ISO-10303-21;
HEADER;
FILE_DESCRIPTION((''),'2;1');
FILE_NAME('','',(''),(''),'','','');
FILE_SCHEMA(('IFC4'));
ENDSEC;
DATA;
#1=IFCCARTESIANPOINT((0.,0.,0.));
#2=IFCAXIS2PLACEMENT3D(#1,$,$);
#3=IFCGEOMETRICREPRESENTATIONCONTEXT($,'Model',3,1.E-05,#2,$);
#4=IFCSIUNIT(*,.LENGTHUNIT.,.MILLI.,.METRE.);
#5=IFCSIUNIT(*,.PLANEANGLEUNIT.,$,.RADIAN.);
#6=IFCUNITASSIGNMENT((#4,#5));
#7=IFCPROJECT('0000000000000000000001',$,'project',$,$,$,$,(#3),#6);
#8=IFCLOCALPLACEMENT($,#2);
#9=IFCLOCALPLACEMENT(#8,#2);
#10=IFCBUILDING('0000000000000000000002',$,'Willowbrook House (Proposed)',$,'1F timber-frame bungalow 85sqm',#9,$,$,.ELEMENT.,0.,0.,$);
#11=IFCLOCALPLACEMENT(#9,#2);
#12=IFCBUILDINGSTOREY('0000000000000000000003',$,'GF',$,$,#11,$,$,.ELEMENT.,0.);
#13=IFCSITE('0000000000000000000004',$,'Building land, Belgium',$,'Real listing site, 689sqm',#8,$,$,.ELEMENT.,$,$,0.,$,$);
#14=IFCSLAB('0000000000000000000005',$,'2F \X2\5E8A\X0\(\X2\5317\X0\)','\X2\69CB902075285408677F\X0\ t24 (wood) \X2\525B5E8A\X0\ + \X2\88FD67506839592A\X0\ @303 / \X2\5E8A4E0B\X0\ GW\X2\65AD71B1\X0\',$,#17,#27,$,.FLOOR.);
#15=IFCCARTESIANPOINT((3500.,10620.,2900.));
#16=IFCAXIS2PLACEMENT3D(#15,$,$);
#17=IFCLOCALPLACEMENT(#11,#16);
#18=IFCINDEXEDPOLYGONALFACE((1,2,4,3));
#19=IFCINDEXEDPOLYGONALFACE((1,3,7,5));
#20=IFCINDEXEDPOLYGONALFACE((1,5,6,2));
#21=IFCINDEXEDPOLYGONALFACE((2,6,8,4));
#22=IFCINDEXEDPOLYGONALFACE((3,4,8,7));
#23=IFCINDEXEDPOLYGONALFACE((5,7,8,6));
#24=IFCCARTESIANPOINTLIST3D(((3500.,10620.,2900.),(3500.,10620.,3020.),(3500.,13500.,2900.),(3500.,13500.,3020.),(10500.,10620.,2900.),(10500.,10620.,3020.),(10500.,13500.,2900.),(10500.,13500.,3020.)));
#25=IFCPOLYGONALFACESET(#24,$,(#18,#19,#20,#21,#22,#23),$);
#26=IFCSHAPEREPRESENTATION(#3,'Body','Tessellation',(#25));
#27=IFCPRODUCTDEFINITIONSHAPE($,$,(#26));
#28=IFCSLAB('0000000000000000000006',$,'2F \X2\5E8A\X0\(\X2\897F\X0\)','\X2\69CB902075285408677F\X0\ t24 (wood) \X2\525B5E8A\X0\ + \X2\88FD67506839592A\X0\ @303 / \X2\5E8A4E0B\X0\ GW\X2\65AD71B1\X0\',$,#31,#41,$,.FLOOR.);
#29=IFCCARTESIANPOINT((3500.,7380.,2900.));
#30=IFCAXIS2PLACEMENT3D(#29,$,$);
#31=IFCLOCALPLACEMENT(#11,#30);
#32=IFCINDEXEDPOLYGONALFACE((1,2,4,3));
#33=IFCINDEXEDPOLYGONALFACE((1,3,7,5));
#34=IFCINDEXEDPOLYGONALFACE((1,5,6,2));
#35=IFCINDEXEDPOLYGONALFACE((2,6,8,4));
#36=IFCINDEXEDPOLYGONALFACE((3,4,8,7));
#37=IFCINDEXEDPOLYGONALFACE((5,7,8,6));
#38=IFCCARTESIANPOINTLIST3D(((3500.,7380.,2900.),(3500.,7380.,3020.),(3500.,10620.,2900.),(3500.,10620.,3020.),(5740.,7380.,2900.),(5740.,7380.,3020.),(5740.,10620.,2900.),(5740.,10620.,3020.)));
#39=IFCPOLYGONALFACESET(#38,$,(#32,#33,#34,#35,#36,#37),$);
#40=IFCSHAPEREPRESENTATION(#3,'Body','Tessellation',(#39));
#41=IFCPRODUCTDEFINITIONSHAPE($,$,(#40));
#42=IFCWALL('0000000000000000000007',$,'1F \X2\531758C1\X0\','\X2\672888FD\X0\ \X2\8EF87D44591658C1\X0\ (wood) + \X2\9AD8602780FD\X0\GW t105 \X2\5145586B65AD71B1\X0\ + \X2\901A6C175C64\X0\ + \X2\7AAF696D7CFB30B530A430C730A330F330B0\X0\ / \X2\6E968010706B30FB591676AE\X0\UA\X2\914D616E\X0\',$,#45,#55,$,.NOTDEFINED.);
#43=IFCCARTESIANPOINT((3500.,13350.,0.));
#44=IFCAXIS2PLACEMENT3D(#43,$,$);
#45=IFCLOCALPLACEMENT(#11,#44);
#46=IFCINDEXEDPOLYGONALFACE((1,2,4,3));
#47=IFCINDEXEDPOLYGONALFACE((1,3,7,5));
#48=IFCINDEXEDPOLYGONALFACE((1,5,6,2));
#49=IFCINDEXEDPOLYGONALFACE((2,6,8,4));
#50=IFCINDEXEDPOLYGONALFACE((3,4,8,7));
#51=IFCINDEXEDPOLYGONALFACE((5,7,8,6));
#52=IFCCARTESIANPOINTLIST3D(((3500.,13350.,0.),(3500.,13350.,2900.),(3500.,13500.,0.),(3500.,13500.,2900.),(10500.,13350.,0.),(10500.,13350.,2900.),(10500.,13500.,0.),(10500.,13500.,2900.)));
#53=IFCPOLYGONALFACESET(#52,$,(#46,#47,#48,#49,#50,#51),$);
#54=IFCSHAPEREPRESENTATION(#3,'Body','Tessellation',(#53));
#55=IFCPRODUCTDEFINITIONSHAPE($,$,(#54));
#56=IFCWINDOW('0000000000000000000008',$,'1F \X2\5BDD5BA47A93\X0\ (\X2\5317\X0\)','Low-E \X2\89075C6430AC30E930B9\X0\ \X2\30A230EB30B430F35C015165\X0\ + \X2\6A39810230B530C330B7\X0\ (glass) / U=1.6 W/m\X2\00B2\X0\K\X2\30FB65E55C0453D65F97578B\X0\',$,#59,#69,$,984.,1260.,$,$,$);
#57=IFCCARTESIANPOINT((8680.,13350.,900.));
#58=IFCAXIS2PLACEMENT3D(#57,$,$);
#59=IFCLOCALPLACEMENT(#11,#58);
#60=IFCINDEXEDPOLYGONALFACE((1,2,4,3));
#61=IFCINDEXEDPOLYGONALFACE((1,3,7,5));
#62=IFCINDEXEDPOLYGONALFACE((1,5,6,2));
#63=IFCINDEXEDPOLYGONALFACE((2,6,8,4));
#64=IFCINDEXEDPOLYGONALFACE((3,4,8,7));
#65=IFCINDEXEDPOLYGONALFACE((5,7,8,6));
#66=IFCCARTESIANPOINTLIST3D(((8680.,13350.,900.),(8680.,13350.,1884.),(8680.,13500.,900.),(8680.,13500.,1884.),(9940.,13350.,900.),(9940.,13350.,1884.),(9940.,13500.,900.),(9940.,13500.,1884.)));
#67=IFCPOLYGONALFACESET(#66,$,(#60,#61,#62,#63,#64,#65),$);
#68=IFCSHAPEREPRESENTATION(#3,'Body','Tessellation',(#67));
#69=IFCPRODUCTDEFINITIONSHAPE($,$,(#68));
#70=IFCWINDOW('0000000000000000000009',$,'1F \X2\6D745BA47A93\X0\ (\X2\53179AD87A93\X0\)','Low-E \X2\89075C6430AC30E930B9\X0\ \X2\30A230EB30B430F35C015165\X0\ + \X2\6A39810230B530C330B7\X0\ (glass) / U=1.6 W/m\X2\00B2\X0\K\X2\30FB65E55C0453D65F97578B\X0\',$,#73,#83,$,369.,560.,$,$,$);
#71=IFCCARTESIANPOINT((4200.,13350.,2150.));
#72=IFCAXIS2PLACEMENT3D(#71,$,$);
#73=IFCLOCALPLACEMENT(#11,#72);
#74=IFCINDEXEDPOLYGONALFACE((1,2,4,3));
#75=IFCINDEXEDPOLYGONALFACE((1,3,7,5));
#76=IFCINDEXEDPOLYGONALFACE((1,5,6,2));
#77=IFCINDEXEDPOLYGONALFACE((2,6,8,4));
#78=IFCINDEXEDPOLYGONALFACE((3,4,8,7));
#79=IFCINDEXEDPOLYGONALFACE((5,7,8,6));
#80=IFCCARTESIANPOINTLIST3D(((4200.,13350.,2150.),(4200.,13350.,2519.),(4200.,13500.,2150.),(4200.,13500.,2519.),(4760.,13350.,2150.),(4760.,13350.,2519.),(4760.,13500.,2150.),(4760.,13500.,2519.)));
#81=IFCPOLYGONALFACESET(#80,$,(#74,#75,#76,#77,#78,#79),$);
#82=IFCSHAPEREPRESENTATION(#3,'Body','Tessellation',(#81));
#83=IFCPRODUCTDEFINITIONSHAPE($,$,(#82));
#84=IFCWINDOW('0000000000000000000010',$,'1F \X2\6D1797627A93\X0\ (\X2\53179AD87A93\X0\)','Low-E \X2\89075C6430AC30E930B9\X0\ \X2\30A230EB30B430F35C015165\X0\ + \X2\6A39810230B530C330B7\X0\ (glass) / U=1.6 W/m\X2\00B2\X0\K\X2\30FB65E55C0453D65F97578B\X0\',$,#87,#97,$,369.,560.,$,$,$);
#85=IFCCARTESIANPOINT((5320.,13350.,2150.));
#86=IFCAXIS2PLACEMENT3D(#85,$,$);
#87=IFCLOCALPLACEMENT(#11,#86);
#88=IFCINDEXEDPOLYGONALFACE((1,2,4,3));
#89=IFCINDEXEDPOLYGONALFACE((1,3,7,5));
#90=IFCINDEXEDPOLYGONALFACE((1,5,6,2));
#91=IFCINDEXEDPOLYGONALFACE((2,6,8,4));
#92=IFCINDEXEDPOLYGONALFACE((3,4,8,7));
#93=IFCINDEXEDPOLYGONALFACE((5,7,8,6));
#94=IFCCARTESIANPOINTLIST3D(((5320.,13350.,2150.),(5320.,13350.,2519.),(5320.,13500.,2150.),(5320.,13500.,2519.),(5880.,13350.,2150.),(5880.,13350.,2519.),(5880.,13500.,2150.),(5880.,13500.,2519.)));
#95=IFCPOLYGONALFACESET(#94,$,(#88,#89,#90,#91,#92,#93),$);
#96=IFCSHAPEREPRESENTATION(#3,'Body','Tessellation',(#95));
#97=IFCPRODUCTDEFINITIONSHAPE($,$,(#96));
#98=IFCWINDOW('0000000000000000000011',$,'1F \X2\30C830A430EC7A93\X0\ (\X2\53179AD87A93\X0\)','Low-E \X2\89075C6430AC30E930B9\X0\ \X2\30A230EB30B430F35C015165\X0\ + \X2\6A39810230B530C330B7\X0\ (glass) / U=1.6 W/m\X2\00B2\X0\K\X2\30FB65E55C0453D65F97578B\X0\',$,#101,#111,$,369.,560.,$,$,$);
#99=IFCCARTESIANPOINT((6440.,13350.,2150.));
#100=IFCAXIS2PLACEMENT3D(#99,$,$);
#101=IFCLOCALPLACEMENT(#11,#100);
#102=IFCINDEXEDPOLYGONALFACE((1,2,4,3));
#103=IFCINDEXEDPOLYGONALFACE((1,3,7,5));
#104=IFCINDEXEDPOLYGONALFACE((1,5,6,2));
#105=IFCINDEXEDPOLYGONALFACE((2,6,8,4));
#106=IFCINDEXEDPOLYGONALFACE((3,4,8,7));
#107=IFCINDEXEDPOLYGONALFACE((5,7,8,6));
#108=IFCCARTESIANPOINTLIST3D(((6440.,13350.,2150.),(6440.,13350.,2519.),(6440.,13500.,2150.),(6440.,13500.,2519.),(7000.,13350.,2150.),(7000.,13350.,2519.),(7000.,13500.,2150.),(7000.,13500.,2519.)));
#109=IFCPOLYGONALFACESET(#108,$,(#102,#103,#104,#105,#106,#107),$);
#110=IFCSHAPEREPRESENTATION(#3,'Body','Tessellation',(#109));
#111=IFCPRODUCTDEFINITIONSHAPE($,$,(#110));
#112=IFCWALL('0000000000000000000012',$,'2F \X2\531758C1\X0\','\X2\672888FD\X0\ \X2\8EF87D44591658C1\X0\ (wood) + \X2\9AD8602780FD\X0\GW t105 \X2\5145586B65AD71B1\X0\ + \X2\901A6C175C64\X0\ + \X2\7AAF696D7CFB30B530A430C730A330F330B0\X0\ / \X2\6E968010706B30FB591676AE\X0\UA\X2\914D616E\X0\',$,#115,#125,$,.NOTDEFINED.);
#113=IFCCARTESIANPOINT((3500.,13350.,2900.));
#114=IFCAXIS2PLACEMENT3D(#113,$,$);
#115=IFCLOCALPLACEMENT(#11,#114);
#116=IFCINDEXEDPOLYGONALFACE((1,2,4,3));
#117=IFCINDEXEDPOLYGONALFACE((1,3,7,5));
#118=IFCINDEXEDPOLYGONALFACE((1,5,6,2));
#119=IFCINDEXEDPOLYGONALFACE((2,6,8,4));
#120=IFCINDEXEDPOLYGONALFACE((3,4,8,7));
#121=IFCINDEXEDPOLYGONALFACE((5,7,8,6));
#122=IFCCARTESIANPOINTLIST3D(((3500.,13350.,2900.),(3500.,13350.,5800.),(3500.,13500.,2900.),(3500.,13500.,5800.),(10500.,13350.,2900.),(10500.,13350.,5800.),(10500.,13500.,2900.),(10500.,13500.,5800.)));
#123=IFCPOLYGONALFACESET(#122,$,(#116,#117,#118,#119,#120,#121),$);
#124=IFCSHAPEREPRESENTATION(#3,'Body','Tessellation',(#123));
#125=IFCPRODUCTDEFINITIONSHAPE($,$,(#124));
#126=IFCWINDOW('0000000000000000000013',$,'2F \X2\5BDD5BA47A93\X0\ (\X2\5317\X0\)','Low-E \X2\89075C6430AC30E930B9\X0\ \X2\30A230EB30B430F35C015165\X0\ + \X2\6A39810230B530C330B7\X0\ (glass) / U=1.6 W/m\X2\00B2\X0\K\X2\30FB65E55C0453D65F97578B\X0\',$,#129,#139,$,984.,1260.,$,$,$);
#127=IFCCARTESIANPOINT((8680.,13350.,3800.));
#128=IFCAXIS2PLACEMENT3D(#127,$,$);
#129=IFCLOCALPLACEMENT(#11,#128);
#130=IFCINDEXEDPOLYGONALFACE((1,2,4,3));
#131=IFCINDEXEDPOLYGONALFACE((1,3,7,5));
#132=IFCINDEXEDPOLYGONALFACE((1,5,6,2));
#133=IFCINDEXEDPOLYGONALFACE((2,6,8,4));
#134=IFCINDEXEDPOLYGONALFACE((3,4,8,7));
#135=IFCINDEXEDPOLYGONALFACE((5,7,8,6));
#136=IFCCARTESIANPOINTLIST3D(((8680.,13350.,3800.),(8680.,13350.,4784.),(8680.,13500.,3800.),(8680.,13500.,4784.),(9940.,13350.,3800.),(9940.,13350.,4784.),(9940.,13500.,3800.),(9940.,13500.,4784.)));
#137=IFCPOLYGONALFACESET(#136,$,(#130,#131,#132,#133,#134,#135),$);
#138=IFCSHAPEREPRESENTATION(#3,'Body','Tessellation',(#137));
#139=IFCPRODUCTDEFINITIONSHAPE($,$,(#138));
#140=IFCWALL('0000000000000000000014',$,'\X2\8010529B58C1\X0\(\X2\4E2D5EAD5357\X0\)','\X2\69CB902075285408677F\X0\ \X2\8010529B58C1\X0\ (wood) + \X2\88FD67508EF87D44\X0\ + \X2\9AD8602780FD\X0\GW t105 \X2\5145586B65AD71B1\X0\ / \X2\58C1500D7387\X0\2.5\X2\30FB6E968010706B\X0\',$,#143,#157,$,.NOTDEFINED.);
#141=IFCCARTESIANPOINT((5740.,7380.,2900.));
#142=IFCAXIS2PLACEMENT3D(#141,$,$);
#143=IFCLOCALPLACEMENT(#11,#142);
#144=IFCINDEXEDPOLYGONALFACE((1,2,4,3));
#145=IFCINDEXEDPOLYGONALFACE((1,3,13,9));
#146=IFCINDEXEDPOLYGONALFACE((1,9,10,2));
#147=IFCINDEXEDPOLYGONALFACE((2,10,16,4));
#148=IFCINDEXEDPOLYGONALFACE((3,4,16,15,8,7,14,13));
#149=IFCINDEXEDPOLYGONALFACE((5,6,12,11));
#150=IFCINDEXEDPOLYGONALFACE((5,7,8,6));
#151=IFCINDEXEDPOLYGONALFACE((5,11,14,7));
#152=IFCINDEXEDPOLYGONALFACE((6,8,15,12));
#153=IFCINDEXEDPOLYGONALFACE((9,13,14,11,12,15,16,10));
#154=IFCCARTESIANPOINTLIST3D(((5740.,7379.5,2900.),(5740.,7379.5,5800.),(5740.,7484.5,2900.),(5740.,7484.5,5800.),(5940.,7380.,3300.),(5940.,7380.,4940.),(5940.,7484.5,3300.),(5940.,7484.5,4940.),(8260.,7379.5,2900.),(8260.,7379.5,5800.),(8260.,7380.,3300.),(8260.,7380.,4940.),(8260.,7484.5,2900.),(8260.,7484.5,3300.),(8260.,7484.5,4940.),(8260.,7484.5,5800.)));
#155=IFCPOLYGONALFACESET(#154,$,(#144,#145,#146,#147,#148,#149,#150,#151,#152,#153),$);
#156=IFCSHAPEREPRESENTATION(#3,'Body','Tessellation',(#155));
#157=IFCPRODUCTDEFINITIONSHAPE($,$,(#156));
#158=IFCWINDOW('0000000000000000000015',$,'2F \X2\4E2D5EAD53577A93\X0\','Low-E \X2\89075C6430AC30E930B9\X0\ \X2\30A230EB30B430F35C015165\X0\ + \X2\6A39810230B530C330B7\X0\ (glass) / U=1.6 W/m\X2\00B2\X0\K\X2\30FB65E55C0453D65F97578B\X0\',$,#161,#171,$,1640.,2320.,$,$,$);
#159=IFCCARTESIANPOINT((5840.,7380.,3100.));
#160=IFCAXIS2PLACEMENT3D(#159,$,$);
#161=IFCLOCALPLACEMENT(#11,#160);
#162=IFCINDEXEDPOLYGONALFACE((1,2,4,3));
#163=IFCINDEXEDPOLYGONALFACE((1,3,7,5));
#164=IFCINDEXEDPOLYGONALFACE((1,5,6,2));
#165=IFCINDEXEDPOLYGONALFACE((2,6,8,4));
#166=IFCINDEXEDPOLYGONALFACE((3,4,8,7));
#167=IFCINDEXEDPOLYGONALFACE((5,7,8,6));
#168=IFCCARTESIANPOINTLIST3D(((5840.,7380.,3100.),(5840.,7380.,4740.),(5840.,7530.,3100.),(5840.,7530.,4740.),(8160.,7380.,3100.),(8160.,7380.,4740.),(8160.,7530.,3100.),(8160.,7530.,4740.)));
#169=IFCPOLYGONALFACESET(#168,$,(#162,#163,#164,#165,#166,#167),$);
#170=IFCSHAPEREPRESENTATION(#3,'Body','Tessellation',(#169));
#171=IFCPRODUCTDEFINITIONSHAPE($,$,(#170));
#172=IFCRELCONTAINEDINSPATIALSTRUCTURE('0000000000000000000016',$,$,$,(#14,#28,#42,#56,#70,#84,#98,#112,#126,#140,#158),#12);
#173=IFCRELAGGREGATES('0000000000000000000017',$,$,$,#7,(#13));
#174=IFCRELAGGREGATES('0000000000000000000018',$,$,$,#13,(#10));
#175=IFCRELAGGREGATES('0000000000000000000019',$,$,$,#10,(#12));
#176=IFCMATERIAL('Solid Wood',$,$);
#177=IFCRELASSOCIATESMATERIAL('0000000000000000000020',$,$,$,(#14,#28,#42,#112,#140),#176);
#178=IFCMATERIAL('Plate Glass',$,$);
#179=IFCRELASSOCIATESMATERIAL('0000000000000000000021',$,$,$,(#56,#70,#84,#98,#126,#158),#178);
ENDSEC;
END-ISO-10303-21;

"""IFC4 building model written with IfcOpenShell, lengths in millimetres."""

from ifc_helpers import new_model, si_unit, frame, frame_2d, origin, place, context, project, spatial, rectangle, extrude, material, element, fill, save


model = new_model("IFC4")

# Units and contexts
model_context = context("Model", 3, precision=1e-05, world=origin())
ifc_project = project(units=[si_unit("LENGTHUNIT", "METRE", prefix="MILLI"), si_unit("PLANEANGLEUNIT", "RADIAN")], contexts=[model_context])

# Site, building, storey
site_placement = place(None, origin())
site = spatial("IfcSite", under=ifc_project, at=site_placement, Name="Building land, Belgium", ObjectType="Real listing site, 689sqm", CompositionType="ELEMENT", RefElevation=0.0)
building_placement = place(site_placement, origin())
building = spatial("IfcBuilding", under=site, at=building_placement, Name="Willowbrook House (Proposed)", ObjectType="1F timber-frame bungalow 85sqm", CompositionType="ELEMENT", ElevationOfRefHeight=0.0, ElevationOfTerrain=0.0)
storey_placement = place(building_placement, origin())
storey = spatial("IfcBuildingStorey", under=building, at=storey_placement, Name="GF", CompositionType="ELEMENT", Elevation=0.0)

# Slabs
ifc_material_1 = material(Name="Solid Wood")
slab_1_placement = place(storey_placement, frame((3500.0, 10620.0, 2900.0)))
element("IfcSlab", 1, at=slab_1_placement, inside=storey, material=ifc_material_1, Name="2F 床(北)", Description="構造用合板 t24 (wood) 剛床 + 製材根太 @303 / 床下 GW断熱", PredefinedType="FLOOR", context=model_context, shape_type="SweptSolid", body=[
    extrude(rectangle(XDim=7000.0, YDim=2880.0, at=frame_2d((3500.0, 1440.0))), frame((3500.0, 10620.0, 2900.0)), (0.0, 0.0, 1.0), 120.0),
])
slab_2_placement = place(storey_placement, frame((3500.0, 7380.0, 2900.0)))
element("IfcSlab", 2, at=slab_2_placement, inside=storey, material=ifc_material_1, Name="2F 床(西)", Description="構造用合板 t24 (wood) 剛床 + 製材根太 @303 / 床下 GW断熱", PredefinedType="FLOOR", context=model_context, shape_type="SweptSolid", body=[
    extrude(rectangle(XDim=2240.0, YDim=3240.0, at=frame_2d((1120.0, 1620.0))), frame((3500.0, 7380.0, 2900.0)), (0.0, 0.0, 1.0), 120.0),
])

# Wall, openings, windows
wall_1_placement = place(storey_placement, frame((3500.0, 13350.0, 0.0)))
wall_1 = element("IfcWall", 3, at=wall_1_placement, inside=storey, material=ifc_material_1, Name="1F 北壁", Description="木製 軸組外壁 (wood) + 高性能GW t105 充填断熱 + 通気層 + 窯業系サイディング / 準耐火・外皮UA配慮", PredefinedType="NOTDEFINED", context=model_context, shape_type="SweptSolid", body=[
    extrude(rectangle(XDim=7000.0, YDim=150.0, at=frame_2d((3500.0, 75.0))), frame((3500.0, 13350.0, 0.0)), (0.0, 0.0, 1.0), 2900.0),
])
opening_1_placement = place(storey_placement, frame((8680.0, 13350.0, 900.0)))
opening_1 = element("IfcOpeningElement", 4, at=opening_1_placement, cuts=wall_1, PredefinedType="NOTDEFINED", context=model_context, shape_type="SweptSolid", body=[
    extrude(rectangle(XDim=1260.0, YDim=150.0, at=frame_2d((630.0, 75.0))), frame((8680.0, 13350.0, 900.0)), (0.0, 0.0, 1.0), 984.0),
])
opening_2_placement = place(storey_placement, frame((4200.0, 13350.0, 2150.0)))
opening_2 = element("IfcOpeningElement", 5, at=opening_2_placement, cuts=wall_1, PredefinedType="NOTDEFINED", context=model_context, shape_type="SweptSolid", body=[
    extrude(rectangle(XDim=560.0, YDim=150.0, at=frame_2d((280.0, 75.0))), frame((4200.0, 13350.0, 2150.0)), (0.0, 0.0, 1.0), 369.0),
])
opening_3_placement = place(storey_placement, frame((5320.0, 13350.0, 2150.0)))
opening_3 = element("IfcOpeningElement", 6, at=opening_3_placement, cuts=wall_1, PredefinedType="NOTDEFINED", context=model_context, shape_type="SweptSolid", body=[
    extrude(rectangle(XDim=560.0, YDim=150.0, at=frame_2d((280.0, 75.0))), frame((5320.0, 13350.0, 2150.0)), (0.0, 0.0, 1.0), 369.0),
])
opening_4_placement = place(storey_placement, frame((6440.0, 13350.0, 2150.0)))
opening_4 = element("IfcOpeningElement", 7, at=opening_4_placement, cuts=wall_1, PredefinedType="NOTDEFINED", context=model_context, shape_type="SweptSolid", body=[
    extrude(rectangle(XDim=560.0, YDim=150.0, at=frame_2d((280.0, 75.0))), frame((6440.0, 13350.0, 2150.0)), (0.0, 0.0, 1.0), 369.0),
])
ifc_material_2 = material(Name="Plate Glass")
window_1_placement = place(storey_placement, frame((8680.0, 13350.0, 900.0)))
window_1 = element("IfcWindow", 8, at=window_1_placement, inside=storey, material=ifc_material_2, Name="1F 寝室窓 (北)", Description="Low-E 複層ガラス アルゴン封入 + 樹脂サッシ (glass) / U=1.6 W/m²K・日射取得型", OverallHeight=984.0, OverallWidth=1260.0, context=model_context, shape_type="SweptSolid", body=[
    extrude(rectangle(XDim=1260.0, YDim=150.0, at=frame_2d((630.0, 75.0))), frame((8680.0, 13350.0, 900.0)), (0.0, 0.0, 1.0), 984.0),
])
fill(opening_1, window_1)
window_2_placement = place(storey_placement, frame((4200.0, 13350.0, 2150.0)))
window_2 = element("IfcWindow", 9, at=window_2_placement, inside=storey, material=ifc_material_2, Name="1F 浴室窓 (北高窓)", Description="Low-E 複層ガラス アルゴン封入 + 樹脂サッシ (glass) / U=1.6 W/m²K・日射取得型", OverallHeight=369.0, OverallWidth=560.0, context=model_context, shape_type="SweptSolid", body=[
    extrude(rectangle(XDim=560.0, YDim=150.0, at=frame_2d((280.0, 75.0))), frame((4200.0, 13350.0, 2150.0)), (0.0, 0.0, 1.0), 369.0),
])
fill(opening_2, window_2)
window_3_placement = place(storey_placement, frame((5320.0, 13350.0, 2150.0)))
window_3 = element("IfcWindow", 10, at=window_3_placement, inside=storey, material=ifc_material_2, Name="1F 洗面窓 (北高窓)", Description="Low-E 複層ガラス アルゴン封入 + 樹脂サッシ (glass) / U=1.6 W/m²K・日射取得型", OverallHeight=369.0, OverallWidth=560.0, context=model_context, shape_type="SweptSolid", body=[
    extrude(rectangle(XDim=560.0, YDim=150.0, at=frame_2d((280.0, 75.0))), frame((5320.0, 13350.0, 2150.0)), (0.0, 0.0, 1.0), 369.0),
])
fill(opening_3, window_3)
window_4_placement = place(storey_placement, frame((6440.0, 13350.0, 2150.0)))
window_4 = element("IfcWindow", 11, at=window_4_placement, inside=storey, material=ifc_material_2, Name="1F トイレ窓 (北高窓)", Description="Low-E 複層ガラス アルゴン封入 + 樹脂サッシ (glass) / U=1.6 W/m²K・日射取得型", OverallHeight=369.0, OverallWidth=560.0, context=model_context, shape_type="SweptSolid", body=[
    extrude(rectangle(XDim=560.0, YDim=150.0, at=frame_2d((280.0, 75.0))), frame((6440.0, 13350.0, 2150.0)), (0.0, 0.0, 1.0), 369.0),
])
fill(opening_4, window_4)

# Walls, openings, windows
wall_2_placement = place(storey_placement, frame((3500.0, 13350.0, 2900.0)))
wall_2 = element("IfcWall", 12, at=wall_2_placement, inside=storey, material=ifc_material_1, Name="2F 北壁", Description="木製 軸組外壁 (wood) + 高性能GW t105 充填断熱 + 通気層 + 窯業系サイディング / 準耐火・外皮UA配慮", PredefinedType="NOTDEFINED", context=model_context, shape_type="SweptSolid", body=[
    extrude(rectangle(XDim=7000.0, YDim=150.0, at=frame_2d((3500.0, 75.0))), frame((3500.0, 13350.0, 2900.0)), (0.0, 0.0, 1.0), 2900.0),
])
opening_5_placement = place(storey_placement, frame((8680.0, 13350.0, 3800.0)))
opening_5 = element("IfcOpeningElement", 13, at=opening_5_placement, cuts=wall_2, PredefinedType="NOTDEFINED", context=model_context, shape_type="SweptSolid", body=[
    extrude(rectangle(XDim=1260.0, YDim=150.0, at=frame_2d((630.0, 75.0))), frame((8680.0, 13350.0, 3800.0)), (0.0, 0.0, 1.0), 984.0),
])
window_5_placement = place(storey_placement, frame((8680.0, 13350.0, 3800.0)))
window_5 = element("IfcWindow", 14, at=window_5_placement, inside=storey, material=ifc_material_2, Name="2F 寝室窓 (北)", Description="Low-E 複層ガラス アルゴン封入 + 樹脂サッシ (glass) / U=1.6 W/m²K・日射取得型", OverallHeight=984.0, OverallWidth=1260.0, context=model_context, shape_type="SweptSolid", body=[
    extrude(rectangle(XDim=1260.0, YDim=150.0, at=frame_2d((630.0, 75.0))), frame((8680.0, 13350.0, 3800.0)), (0.0, 0.0, 1.0), 984.0),
])
fill(opening_5, window_5)
wall_3_placement = place(storey_placement, frame((5740.0, 7380.0, 2900.0)))
wall_3 = element("IfcWall", 15, at=wall_3_placement, inside=storey, material=ifc_material_1, Name="耐力壁(中庭南)", Description="構造用合板 耐力壁 (wood) + 製材軸組 + 高性能GW t105 充填断熱 / 壁倍率2.5・準耐火", PredefinedType="NOTDEFINED", context=model_context, shape_type="SweptSolid", body=[
    extrude(rectangle(XDim=2520.0, YDim=105.0, at=frame_2d((1260.0, 52.0))), frame((5740.0, 7380.0, 2900.0)), (0.0, 0.0, 1.0), 2900.0),
])
opening_6_placement = place(storey_placement, frame((5840.0, 7380.0, 3100.0)))
opening_6 = element("IfcOpeningElement", 16, at=opening_6_placement, cuts=wall_3, PredefinedType="NOTDEFINED", context=model_context, shape_type="SweptSolid", body=[
    extrude(rectangle(XDim=2320.0, YDim=150.0, at=frame_2d((1160.0, 75.0))), frame((5840.0, 7380.0, 3100.0)), (0.0, 0.0, 1.0), 1640.0),
])
window_6_placement = place(storey_placement, frame((5840.0, 7380.0, 3100.0)))
window_6 = element("IfcWindow", 17, at=window_6_placement, inside=storey, material=ifc_material_2, Name="2F 中庭南窓", Description="Low-E 複層ガラス アルゴン封入 + 樹脂サッシ (glass) / U=1.6 W/m²K・日射取得型", OverallHeight=1640.0, OverallWidth=2320.0, context=model_context, shape_type="SweptSolid", body=[
    extrude(rectangle(XDim=2320.0, YDim=150.0, at=frame_2d((1160.0, 75.0))), frame((5840.0, 7380.0, 3100.0)), (0.0, 0.0, 1.0), 1640.0),
])
fill(opening_6, window_6)

save(model, "model.ifc")
